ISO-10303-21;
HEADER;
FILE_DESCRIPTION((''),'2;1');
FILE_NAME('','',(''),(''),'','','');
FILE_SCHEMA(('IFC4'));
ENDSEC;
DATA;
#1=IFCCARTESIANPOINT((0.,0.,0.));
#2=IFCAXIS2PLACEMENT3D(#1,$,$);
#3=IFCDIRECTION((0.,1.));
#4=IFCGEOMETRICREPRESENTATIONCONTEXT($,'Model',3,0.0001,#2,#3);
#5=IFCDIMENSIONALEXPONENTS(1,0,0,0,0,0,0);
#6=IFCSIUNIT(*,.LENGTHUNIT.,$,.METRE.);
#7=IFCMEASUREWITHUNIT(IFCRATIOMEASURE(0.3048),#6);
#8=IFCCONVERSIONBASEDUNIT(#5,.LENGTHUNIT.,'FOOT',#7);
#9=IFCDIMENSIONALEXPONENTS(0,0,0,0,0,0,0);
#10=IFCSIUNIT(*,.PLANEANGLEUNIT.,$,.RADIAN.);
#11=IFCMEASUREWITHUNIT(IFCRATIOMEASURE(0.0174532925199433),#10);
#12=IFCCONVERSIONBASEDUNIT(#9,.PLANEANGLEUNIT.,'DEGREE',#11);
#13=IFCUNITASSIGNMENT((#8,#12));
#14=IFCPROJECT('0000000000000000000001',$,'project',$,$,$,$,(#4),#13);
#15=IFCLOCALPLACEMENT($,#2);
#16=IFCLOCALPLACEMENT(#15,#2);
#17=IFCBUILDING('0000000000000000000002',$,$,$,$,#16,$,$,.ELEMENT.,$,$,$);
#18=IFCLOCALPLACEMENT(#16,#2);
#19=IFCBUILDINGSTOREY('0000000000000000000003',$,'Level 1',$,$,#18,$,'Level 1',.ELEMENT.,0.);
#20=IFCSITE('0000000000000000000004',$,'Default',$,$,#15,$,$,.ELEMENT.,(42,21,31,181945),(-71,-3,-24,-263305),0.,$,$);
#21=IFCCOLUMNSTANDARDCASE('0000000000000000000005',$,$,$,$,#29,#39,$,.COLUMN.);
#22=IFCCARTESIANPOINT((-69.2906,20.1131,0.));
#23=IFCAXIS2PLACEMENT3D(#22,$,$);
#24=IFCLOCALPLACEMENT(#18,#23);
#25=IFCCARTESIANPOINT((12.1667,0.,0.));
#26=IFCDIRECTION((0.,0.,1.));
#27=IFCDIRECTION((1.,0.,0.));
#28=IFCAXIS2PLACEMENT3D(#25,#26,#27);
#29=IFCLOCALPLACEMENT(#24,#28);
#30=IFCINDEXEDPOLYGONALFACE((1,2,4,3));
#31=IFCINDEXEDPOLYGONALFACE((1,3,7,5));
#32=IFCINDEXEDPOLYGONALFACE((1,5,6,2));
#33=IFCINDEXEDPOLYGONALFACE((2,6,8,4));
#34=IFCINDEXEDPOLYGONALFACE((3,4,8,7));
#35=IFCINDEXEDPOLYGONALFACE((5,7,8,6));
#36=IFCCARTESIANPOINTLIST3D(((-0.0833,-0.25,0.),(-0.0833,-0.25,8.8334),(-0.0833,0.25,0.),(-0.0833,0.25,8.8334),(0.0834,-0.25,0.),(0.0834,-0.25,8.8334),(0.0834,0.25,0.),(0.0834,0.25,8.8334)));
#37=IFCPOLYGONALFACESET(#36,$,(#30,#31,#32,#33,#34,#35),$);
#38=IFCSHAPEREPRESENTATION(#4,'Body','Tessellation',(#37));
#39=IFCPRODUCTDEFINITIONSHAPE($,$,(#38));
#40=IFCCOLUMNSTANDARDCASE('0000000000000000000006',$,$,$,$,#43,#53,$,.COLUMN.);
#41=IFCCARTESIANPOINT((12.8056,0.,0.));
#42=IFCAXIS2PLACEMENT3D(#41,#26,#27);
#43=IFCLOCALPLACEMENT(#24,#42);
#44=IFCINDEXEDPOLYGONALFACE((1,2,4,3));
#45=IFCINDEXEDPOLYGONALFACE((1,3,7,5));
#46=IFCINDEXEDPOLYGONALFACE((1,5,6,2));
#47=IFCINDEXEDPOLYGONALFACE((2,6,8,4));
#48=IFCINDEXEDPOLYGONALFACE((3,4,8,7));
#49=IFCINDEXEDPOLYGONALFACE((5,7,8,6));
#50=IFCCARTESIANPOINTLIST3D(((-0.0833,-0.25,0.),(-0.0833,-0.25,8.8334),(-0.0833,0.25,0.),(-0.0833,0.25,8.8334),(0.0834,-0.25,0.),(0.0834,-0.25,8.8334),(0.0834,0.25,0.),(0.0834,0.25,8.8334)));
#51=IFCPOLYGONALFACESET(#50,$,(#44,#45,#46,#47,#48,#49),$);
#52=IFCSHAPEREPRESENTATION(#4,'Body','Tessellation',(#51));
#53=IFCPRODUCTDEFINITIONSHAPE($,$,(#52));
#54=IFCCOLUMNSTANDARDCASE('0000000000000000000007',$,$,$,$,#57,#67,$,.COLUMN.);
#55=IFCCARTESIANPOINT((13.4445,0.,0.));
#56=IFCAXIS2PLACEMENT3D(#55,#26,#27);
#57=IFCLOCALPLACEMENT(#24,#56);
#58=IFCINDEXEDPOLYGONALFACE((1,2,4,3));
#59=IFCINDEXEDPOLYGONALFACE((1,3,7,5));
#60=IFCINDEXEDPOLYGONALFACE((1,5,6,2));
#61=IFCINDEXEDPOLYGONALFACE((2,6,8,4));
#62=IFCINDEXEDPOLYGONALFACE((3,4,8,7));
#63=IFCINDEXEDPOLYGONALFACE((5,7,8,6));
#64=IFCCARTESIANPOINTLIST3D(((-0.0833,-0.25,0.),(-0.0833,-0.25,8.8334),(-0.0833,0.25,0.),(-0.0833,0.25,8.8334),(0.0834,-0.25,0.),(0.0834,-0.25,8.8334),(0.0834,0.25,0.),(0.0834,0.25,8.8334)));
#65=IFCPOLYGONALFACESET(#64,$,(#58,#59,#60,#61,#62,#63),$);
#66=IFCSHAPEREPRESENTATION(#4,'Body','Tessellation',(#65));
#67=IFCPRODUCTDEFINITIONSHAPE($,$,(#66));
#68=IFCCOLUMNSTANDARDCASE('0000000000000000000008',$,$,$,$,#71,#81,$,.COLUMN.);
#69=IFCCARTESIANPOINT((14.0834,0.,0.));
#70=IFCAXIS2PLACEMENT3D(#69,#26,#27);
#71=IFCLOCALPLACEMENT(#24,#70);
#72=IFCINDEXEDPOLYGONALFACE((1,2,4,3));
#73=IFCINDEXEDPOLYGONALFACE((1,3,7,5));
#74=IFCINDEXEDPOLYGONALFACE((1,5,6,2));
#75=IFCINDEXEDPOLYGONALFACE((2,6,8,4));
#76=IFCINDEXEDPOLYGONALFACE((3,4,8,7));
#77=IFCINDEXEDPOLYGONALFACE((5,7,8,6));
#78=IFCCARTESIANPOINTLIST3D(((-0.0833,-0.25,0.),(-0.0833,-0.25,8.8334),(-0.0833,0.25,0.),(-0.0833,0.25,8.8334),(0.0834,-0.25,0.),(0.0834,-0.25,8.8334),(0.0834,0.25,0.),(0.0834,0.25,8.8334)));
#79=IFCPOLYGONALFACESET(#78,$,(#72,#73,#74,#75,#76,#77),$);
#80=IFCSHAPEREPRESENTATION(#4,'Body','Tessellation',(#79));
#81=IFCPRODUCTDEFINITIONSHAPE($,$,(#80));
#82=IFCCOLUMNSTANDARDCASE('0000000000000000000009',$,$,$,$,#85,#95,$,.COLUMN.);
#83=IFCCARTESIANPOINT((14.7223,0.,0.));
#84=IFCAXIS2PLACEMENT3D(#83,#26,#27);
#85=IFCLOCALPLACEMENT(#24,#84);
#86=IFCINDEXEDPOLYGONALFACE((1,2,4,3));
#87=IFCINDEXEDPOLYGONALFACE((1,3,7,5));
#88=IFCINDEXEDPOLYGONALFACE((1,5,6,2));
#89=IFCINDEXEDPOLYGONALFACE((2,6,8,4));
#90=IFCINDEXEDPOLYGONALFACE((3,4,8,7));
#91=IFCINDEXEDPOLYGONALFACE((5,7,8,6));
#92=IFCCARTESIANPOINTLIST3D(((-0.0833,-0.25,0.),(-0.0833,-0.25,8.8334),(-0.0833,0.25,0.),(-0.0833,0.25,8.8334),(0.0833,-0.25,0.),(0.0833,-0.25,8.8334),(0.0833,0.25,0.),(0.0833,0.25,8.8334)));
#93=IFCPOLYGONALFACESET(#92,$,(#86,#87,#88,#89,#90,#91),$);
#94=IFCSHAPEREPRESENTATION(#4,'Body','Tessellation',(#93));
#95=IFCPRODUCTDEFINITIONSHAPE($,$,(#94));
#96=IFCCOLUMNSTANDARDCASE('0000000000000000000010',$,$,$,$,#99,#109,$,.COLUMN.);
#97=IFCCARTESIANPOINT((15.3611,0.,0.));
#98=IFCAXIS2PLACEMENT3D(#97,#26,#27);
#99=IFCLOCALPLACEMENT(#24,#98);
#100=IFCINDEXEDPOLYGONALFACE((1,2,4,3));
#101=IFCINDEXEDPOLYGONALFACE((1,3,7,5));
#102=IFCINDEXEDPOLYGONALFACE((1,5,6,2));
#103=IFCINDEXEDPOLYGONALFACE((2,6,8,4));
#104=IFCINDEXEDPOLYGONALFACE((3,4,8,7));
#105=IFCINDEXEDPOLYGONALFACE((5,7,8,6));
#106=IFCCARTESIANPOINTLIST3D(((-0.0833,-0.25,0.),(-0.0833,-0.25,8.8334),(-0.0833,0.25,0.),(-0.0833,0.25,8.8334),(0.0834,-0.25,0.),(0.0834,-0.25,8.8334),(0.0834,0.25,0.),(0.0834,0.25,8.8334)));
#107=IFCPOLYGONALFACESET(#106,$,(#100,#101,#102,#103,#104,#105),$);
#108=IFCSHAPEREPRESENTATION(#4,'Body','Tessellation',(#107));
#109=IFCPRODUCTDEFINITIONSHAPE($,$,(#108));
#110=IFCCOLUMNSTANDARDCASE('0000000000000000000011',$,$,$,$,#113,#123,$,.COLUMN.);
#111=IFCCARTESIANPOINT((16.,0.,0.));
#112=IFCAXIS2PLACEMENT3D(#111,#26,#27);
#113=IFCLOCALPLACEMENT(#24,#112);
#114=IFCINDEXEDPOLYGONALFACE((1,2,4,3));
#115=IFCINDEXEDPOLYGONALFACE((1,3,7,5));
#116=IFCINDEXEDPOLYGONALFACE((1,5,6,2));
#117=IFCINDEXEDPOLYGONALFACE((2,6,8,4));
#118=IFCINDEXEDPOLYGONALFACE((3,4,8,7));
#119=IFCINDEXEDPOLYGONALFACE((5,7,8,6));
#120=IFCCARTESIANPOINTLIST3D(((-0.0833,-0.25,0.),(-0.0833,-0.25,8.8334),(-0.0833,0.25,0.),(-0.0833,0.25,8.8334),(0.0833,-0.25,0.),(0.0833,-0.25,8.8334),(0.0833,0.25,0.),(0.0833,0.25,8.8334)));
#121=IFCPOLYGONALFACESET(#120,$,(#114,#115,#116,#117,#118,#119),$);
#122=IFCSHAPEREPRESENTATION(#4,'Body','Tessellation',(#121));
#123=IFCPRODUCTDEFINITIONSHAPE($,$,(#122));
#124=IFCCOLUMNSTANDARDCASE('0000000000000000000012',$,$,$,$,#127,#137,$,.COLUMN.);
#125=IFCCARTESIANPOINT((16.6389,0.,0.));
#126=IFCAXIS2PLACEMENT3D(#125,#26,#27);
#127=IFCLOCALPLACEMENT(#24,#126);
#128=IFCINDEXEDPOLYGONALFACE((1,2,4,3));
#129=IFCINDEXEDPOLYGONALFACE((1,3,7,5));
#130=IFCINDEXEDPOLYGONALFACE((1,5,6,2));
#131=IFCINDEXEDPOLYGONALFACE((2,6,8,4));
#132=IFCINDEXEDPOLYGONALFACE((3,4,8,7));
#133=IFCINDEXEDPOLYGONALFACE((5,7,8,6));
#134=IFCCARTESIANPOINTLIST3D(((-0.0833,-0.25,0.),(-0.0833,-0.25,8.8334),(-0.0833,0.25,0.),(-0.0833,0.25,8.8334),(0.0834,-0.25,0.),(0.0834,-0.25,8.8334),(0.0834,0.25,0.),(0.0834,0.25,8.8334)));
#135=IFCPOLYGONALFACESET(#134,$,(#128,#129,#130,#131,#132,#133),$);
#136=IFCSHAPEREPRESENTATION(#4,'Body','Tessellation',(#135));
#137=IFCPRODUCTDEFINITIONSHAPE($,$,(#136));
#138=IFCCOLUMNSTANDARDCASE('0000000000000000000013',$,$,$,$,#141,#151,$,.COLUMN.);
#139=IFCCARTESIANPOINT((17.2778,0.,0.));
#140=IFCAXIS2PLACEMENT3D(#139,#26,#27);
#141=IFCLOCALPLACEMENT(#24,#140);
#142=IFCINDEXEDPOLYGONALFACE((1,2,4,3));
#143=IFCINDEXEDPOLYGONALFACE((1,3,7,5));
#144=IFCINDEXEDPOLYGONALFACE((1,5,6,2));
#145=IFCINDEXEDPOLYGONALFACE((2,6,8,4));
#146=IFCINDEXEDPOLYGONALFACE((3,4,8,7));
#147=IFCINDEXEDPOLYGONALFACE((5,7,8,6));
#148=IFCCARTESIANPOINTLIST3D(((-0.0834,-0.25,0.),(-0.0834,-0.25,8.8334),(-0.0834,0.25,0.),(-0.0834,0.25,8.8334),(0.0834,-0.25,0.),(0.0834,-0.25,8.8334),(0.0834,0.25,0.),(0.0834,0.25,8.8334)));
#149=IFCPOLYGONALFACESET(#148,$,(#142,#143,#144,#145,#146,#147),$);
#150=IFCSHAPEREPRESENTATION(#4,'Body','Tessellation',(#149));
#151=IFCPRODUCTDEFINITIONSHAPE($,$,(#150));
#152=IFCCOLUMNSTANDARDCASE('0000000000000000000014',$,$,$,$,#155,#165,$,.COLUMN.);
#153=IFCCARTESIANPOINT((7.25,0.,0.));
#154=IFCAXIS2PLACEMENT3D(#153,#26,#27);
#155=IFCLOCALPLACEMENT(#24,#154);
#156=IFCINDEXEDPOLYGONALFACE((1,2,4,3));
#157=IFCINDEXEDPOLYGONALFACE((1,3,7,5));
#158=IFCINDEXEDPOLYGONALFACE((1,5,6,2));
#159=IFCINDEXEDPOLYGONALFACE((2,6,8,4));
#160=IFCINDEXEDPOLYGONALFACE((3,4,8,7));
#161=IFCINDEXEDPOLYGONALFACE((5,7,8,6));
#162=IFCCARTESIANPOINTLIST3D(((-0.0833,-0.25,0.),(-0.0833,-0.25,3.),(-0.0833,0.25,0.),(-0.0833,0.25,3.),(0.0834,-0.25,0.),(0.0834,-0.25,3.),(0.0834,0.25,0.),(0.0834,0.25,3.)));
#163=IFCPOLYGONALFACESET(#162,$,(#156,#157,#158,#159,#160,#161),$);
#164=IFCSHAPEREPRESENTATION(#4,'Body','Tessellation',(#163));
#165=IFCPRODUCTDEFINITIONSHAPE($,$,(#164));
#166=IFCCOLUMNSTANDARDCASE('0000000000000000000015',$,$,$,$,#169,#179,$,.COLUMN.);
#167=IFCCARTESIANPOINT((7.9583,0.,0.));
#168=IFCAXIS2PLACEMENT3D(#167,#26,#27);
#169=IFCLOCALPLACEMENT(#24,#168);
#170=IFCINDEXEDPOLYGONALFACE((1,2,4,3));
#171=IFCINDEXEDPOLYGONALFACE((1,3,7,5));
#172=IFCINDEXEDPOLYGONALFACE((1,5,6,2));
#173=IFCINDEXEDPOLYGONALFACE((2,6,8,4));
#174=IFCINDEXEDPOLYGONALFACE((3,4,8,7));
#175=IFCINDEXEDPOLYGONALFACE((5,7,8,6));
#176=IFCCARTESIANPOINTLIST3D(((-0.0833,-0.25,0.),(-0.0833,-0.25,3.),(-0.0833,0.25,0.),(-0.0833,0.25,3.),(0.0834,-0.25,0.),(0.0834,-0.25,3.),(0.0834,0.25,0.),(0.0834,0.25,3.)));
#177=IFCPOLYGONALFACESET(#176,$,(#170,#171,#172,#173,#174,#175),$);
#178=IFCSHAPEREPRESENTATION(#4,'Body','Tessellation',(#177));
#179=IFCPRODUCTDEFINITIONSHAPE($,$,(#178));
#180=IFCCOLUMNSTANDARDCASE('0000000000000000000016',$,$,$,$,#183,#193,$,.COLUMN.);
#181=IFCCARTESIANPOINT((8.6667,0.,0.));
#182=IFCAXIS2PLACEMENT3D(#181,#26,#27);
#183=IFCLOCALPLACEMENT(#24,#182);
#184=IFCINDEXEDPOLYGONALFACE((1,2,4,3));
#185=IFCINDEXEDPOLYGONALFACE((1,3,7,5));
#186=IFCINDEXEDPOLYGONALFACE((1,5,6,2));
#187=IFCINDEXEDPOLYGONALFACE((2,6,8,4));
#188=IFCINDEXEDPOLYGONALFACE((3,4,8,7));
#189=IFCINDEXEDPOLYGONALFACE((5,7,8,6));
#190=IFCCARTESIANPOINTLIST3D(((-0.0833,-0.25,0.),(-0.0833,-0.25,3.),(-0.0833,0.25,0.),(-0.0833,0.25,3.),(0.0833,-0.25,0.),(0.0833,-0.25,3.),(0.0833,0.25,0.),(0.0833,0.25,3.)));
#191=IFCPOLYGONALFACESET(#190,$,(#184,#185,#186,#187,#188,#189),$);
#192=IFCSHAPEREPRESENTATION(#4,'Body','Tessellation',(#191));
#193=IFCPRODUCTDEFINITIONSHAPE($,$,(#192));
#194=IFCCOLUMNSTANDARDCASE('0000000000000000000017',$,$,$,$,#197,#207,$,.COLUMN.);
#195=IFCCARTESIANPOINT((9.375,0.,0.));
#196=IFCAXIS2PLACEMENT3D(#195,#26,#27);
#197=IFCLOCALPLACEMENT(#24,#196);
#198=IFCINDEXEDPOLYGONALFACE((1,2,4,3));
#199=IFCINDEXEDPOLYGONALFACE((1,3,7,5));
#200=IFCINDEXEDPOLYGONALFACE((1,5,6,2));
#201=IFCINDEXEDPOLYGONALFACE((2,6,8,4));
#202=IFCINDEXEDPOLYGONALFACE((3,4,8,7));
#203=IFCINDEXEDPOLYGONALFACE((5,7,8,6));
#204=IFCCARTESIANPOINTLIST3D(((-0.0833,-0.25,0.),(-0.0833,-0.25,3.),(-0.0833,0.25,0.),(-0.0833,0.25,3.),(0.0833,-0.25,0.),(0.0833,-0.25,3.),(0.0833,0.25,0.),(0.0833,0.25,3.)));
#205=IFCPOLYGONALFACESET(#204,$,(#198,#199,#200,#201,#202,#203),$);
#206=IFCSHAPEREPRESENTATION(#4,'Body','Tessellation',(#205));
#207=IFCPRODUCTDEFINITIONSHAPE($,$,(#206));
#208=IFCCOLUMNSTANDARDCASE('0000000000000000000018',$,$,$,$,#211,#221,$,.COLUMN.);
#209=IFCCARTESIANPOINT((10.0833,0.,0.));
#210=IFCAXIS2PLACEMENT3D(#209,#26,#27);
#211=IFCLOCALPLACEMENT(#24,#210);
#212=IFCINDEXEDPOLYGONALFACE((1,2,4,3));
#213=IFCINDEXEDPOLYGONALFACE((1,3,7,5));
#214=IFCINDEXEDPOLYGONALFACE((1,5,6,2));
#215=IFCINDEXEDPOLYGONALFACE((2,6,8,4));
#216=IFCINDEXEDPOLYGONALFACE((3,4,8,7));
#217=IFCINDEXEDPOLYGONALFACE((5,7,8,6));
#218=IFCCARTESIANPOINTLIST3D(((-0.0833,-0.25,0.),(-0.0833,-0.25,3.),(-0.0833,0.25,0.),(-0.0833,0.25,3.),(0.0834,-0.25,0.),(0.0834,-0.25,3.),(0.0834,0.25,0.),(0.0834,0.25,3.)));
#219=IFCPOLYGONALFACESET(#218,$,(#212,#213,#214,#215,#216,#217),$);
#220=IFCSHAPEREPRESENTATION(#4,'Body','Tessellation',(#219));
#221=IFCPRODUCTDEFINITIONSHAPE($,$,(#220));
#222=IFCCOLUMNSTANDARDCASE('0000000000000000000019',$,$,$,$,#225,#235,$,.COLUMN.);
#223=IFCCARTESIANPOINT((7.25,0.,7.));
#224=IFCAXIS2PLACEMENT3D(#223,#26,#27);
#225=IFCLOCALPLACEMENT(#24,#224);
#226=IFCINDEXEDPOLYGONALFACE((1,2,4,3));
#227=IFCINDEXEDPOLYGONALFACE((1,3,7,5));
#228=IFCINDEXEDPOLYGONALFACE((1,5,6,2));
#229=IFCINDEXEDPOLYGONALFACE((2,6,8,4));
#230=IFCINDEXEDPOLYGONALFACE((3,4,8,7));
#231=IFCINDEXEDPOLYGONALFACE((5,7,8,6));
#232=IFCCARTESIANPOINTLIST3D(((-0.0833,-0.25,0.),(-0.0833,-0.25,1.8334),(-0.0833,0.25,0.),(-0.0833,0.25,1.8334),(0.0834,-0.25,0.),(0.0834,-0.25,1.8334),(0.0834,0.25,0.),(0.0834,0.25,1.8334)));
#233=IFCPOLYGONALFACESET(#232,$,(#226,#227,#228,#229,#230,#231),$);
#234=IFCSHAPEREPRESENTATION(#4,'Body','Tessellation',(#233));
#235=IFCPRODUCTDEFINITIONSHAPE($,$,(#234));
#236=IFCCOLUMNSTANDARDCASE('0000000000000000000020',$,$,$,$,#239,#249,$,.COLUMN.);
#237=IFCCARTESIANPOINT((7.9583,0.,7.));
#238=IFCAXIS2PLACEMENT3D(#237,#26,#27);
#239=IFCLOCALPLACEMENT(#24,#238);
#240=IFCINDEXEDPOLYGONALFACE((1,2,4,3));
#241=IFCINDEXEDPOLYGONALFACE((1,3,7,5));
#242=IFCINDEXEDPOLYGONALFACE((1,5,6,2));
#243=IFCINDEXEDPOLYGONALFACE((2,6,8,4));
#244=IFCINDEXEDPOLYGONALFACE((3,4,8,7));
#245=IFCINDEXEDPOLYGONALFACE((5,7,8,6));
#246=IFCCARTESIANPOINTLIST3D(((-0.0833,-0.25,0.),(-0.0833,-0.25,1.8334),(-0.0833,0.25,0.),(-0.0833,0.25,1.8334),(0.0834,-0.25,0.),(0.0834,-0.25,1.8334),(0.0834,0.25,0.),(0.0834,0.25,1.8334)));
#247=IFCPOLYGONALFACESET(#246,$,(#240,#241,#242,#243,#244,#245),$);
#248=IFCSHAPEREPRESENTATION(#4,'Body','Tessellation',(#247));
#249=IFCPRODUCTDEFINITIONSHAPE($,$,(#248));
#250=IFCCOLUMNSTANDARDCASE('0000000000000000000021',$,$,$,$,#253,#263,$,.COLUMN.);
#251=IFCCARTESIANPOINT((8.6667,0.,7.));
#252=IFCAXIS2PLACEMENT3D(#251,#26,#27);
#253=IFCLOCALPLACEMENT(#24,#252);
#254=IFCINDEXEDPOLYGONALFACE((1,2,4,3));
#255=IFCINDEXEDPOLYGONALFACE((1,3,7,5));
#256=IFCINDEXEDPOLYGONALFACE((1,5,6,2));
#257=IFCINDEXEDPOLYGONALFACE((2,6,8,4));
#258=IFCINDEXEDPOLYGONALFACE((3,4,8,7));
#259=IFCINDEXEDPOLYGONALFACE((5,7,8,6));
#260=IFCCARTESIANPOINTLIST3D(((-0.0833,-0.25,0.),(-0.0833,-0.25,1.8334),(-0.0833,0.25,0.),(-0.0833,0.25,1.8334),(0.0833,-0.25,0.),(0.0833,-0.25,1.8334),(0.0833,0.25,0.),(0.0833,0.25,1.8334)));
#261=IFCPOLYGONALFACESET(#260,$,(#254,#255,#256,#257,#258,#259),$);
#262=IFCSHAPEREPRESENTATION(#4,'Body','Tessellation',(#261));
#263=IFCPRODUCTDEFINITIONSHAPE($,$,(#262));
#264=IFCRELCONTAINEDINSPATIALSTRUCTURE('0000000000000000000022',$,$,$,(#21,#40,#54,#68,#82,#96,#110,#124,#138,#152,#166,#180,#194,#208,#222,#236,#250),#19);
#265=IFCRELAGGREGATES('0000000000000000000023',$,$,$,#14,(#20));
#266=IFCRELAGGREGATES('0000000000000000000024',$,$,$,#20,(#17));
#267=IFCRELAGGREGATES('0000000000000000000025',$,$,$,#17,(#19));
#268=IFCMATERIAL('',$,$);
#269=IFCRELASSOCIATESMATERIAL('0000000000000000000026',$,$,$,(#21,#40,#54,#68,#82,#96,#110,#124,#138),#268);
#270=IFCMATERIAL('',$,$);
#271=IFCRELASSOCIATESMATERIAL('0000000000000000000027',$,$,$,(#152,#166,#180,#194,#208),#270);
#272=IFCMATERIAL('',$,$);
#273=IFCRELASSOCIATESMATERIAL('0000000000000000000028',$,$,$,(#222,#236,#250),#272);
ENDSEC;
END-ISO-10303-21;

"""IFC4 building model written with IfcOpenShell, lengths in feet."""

from ifc_helpers import new_model, entity, si_unit, converted_unit, direction, frame, origin, place, context, project, spatial, rectangle, extrude, material, element, save


model = new_model("IFC4")

# Units and contexts
model_context = context("Model", 3, precision=0.0001, world=origin(), true_north=direction((0.0, 1.0)))
ifc_project = project(units=[converted_unit("LENGTHUNIT", "FOOT", entity("IfcRatioMeasure", 0.3048), si_unit("LENGTHUNIT", "METRE"), dimensions=[1, 0, 0, 0, 0, 0, 0]), converted_unit("PLANEANGLEUNIT", "DEGREE", entity("IfcRatioMeasure", 0.0174532925199433), si_unit("PLANEANGLEUNIT", "RADIAN"), dimensions=[0, 0, 0, 0, 0, 0, 0])], contexts=[model_context])

# Site, building, storey
site_placement = place(None, origin())
site = spatial("IfcSite", under=ifc_project, at=site_placement, Name="Default", CompositionType="ELEMENT", RefLatitude=(42, 21, 31, 181945), RefLongitude=(-71, -3, -24, -263305), RefElevation=0.0)
building_placement = place(site_placement, origin())
building = spatial("IfcBuilding", under=site, at=building_placement, CompositionType="ELEMENT")
storey_placement = place(building_placement, origin())
storey = spatial("IfcBuildingStorey", under=building, at=storey_placement, Name="Level 1", LongName="Level 1", CompositionType="ELEMENT", Elevation=0.0)

# Columns
ifc_material_1 = material(Name="")
placement_1 = place(storey_placement, frame((-69.2906, 20.1131, 0.0)))
for number, where, z_axis, x_axis in (
    (1, (12.1667, 0.0, 0.0), (0.0, 0.0, 1.0), (1.0, 0.0, 0.0)),
    (2, (12.8056, 0.0, 0.0), (0.0, 0.0, 1.0), (1.0, 0.0, 0.0)),
    (3, (13.4445, 0.0, 0.0), (0.0, 0.0, 1.0), (1.0, 0.0, 0.0)),
    (4, (14.0834, 0.0, 0.0), (0.0, 0.0, 1.0), (1.0, 0.0, 0.0)),
    (5, (14.7223, 0.0, 0.0), (0.0, 0.0, 1.0), (1.0, 0.0, 0.0)),
    (6, (15.3611, 0.0, 0.0), (0.0, 0.0, 1.0), (1.0, 0.0, 0.0)),
    (7, (16.0, 0.0, 0.0), (0.0, 0.0, 1.0), (1.0, 0.0, 0.0)),
    (8, (16.6389, 0.0, 0.0), (0.0, 0.0, 1.0), (1.0, 0.0, 0.0)),
    (9, (17.2778, 0.0, 0.0), (0.0, 0.0, 1.0), (1.0, 0.0, 0.0)),
):
    element("IfcColumnStandardCase", number, at=place(placement_1, frame(where, z_axis=z_axis, x_axis=x_axis)), inside=storey, material=ifc_material_1, PredefinedType="COLUMN", context=model_context, shape_type="SweptSolid", body=[
        extrude(rectangle(XDim=0.1667, YDim=0.5), origin(), (0.0, 0.0, 1.0), 8.8334),
    ])
ifc_material_2 = material(Name="")
for number, where, z_axis, x_axis in (
    (10, (7.25, 0.0, 0.0), (0.0, 0.0, 1.0), (1.0, 0.0, 0.0)),
    (11, (7.9583, 0.0, 0.0), (0.0, 0.0, 1.0), (1.0, 0.0, 0.0)),
    (12, (8.6667, 0.0, 0.0), (0.0, 0.0, 1.0), (1.0, 0.0, 0.0)),
    (13, (9.375, 0.0, 0.0), (0.0, 0.0, 1.0), (1.0, 0.0, 0.0)),
    (14, (10.0833, 0.0, 0.0), (0.0, 0.0, 1.0), (1.0, 0.0, 0.0)),
):
    element("IfcColumnStandardCase", number, at=place(placement_1, frame(where, z_axis=z_axis, x_axis=x_axis)), inside=storey, material=ifc_material_2, PredefinedType="COLUMN", context=model_context, shape_type="SweptSolid", body=[
        extrude(rectangle(XDim=0.1667, YDim=0.5), origin(), (0.0, 0.0, 1.0), 3.0),
    ])
ifc_material_3 = material(Name="")
for number, where, z_axis, x_axis in (
    (15, (7.25, 0.0, 7.0), (0.0, 0.0, 1.0), (1.0, 0.0, 0.0)),
    (16, (7.9583, 0.0, 7.0), (0.0, 0.0, 1.0), (1.0, 0.0, 0.0)),
    (17, (8.6667, 0.0, 7.0), (0.0, 0.0, 1.0), (1.0, 0.0, 0.0)),
):
    element("IfcColumnStandardCase", number, at=place(placement_1, frame(where, z_axis=z_axis, x_axis=x_axis)), inside=storey, material=ifc_material_3, PredefinedType="COLUMN", context=model_context, shape_type="SweptSolid", body=[
        extrude(rectangle(XDim=0.1667, YDim=0.5), origin(), (0.0, 0.0, 1.0), 1.8334),
    ])

save(model, "model.ifc")
